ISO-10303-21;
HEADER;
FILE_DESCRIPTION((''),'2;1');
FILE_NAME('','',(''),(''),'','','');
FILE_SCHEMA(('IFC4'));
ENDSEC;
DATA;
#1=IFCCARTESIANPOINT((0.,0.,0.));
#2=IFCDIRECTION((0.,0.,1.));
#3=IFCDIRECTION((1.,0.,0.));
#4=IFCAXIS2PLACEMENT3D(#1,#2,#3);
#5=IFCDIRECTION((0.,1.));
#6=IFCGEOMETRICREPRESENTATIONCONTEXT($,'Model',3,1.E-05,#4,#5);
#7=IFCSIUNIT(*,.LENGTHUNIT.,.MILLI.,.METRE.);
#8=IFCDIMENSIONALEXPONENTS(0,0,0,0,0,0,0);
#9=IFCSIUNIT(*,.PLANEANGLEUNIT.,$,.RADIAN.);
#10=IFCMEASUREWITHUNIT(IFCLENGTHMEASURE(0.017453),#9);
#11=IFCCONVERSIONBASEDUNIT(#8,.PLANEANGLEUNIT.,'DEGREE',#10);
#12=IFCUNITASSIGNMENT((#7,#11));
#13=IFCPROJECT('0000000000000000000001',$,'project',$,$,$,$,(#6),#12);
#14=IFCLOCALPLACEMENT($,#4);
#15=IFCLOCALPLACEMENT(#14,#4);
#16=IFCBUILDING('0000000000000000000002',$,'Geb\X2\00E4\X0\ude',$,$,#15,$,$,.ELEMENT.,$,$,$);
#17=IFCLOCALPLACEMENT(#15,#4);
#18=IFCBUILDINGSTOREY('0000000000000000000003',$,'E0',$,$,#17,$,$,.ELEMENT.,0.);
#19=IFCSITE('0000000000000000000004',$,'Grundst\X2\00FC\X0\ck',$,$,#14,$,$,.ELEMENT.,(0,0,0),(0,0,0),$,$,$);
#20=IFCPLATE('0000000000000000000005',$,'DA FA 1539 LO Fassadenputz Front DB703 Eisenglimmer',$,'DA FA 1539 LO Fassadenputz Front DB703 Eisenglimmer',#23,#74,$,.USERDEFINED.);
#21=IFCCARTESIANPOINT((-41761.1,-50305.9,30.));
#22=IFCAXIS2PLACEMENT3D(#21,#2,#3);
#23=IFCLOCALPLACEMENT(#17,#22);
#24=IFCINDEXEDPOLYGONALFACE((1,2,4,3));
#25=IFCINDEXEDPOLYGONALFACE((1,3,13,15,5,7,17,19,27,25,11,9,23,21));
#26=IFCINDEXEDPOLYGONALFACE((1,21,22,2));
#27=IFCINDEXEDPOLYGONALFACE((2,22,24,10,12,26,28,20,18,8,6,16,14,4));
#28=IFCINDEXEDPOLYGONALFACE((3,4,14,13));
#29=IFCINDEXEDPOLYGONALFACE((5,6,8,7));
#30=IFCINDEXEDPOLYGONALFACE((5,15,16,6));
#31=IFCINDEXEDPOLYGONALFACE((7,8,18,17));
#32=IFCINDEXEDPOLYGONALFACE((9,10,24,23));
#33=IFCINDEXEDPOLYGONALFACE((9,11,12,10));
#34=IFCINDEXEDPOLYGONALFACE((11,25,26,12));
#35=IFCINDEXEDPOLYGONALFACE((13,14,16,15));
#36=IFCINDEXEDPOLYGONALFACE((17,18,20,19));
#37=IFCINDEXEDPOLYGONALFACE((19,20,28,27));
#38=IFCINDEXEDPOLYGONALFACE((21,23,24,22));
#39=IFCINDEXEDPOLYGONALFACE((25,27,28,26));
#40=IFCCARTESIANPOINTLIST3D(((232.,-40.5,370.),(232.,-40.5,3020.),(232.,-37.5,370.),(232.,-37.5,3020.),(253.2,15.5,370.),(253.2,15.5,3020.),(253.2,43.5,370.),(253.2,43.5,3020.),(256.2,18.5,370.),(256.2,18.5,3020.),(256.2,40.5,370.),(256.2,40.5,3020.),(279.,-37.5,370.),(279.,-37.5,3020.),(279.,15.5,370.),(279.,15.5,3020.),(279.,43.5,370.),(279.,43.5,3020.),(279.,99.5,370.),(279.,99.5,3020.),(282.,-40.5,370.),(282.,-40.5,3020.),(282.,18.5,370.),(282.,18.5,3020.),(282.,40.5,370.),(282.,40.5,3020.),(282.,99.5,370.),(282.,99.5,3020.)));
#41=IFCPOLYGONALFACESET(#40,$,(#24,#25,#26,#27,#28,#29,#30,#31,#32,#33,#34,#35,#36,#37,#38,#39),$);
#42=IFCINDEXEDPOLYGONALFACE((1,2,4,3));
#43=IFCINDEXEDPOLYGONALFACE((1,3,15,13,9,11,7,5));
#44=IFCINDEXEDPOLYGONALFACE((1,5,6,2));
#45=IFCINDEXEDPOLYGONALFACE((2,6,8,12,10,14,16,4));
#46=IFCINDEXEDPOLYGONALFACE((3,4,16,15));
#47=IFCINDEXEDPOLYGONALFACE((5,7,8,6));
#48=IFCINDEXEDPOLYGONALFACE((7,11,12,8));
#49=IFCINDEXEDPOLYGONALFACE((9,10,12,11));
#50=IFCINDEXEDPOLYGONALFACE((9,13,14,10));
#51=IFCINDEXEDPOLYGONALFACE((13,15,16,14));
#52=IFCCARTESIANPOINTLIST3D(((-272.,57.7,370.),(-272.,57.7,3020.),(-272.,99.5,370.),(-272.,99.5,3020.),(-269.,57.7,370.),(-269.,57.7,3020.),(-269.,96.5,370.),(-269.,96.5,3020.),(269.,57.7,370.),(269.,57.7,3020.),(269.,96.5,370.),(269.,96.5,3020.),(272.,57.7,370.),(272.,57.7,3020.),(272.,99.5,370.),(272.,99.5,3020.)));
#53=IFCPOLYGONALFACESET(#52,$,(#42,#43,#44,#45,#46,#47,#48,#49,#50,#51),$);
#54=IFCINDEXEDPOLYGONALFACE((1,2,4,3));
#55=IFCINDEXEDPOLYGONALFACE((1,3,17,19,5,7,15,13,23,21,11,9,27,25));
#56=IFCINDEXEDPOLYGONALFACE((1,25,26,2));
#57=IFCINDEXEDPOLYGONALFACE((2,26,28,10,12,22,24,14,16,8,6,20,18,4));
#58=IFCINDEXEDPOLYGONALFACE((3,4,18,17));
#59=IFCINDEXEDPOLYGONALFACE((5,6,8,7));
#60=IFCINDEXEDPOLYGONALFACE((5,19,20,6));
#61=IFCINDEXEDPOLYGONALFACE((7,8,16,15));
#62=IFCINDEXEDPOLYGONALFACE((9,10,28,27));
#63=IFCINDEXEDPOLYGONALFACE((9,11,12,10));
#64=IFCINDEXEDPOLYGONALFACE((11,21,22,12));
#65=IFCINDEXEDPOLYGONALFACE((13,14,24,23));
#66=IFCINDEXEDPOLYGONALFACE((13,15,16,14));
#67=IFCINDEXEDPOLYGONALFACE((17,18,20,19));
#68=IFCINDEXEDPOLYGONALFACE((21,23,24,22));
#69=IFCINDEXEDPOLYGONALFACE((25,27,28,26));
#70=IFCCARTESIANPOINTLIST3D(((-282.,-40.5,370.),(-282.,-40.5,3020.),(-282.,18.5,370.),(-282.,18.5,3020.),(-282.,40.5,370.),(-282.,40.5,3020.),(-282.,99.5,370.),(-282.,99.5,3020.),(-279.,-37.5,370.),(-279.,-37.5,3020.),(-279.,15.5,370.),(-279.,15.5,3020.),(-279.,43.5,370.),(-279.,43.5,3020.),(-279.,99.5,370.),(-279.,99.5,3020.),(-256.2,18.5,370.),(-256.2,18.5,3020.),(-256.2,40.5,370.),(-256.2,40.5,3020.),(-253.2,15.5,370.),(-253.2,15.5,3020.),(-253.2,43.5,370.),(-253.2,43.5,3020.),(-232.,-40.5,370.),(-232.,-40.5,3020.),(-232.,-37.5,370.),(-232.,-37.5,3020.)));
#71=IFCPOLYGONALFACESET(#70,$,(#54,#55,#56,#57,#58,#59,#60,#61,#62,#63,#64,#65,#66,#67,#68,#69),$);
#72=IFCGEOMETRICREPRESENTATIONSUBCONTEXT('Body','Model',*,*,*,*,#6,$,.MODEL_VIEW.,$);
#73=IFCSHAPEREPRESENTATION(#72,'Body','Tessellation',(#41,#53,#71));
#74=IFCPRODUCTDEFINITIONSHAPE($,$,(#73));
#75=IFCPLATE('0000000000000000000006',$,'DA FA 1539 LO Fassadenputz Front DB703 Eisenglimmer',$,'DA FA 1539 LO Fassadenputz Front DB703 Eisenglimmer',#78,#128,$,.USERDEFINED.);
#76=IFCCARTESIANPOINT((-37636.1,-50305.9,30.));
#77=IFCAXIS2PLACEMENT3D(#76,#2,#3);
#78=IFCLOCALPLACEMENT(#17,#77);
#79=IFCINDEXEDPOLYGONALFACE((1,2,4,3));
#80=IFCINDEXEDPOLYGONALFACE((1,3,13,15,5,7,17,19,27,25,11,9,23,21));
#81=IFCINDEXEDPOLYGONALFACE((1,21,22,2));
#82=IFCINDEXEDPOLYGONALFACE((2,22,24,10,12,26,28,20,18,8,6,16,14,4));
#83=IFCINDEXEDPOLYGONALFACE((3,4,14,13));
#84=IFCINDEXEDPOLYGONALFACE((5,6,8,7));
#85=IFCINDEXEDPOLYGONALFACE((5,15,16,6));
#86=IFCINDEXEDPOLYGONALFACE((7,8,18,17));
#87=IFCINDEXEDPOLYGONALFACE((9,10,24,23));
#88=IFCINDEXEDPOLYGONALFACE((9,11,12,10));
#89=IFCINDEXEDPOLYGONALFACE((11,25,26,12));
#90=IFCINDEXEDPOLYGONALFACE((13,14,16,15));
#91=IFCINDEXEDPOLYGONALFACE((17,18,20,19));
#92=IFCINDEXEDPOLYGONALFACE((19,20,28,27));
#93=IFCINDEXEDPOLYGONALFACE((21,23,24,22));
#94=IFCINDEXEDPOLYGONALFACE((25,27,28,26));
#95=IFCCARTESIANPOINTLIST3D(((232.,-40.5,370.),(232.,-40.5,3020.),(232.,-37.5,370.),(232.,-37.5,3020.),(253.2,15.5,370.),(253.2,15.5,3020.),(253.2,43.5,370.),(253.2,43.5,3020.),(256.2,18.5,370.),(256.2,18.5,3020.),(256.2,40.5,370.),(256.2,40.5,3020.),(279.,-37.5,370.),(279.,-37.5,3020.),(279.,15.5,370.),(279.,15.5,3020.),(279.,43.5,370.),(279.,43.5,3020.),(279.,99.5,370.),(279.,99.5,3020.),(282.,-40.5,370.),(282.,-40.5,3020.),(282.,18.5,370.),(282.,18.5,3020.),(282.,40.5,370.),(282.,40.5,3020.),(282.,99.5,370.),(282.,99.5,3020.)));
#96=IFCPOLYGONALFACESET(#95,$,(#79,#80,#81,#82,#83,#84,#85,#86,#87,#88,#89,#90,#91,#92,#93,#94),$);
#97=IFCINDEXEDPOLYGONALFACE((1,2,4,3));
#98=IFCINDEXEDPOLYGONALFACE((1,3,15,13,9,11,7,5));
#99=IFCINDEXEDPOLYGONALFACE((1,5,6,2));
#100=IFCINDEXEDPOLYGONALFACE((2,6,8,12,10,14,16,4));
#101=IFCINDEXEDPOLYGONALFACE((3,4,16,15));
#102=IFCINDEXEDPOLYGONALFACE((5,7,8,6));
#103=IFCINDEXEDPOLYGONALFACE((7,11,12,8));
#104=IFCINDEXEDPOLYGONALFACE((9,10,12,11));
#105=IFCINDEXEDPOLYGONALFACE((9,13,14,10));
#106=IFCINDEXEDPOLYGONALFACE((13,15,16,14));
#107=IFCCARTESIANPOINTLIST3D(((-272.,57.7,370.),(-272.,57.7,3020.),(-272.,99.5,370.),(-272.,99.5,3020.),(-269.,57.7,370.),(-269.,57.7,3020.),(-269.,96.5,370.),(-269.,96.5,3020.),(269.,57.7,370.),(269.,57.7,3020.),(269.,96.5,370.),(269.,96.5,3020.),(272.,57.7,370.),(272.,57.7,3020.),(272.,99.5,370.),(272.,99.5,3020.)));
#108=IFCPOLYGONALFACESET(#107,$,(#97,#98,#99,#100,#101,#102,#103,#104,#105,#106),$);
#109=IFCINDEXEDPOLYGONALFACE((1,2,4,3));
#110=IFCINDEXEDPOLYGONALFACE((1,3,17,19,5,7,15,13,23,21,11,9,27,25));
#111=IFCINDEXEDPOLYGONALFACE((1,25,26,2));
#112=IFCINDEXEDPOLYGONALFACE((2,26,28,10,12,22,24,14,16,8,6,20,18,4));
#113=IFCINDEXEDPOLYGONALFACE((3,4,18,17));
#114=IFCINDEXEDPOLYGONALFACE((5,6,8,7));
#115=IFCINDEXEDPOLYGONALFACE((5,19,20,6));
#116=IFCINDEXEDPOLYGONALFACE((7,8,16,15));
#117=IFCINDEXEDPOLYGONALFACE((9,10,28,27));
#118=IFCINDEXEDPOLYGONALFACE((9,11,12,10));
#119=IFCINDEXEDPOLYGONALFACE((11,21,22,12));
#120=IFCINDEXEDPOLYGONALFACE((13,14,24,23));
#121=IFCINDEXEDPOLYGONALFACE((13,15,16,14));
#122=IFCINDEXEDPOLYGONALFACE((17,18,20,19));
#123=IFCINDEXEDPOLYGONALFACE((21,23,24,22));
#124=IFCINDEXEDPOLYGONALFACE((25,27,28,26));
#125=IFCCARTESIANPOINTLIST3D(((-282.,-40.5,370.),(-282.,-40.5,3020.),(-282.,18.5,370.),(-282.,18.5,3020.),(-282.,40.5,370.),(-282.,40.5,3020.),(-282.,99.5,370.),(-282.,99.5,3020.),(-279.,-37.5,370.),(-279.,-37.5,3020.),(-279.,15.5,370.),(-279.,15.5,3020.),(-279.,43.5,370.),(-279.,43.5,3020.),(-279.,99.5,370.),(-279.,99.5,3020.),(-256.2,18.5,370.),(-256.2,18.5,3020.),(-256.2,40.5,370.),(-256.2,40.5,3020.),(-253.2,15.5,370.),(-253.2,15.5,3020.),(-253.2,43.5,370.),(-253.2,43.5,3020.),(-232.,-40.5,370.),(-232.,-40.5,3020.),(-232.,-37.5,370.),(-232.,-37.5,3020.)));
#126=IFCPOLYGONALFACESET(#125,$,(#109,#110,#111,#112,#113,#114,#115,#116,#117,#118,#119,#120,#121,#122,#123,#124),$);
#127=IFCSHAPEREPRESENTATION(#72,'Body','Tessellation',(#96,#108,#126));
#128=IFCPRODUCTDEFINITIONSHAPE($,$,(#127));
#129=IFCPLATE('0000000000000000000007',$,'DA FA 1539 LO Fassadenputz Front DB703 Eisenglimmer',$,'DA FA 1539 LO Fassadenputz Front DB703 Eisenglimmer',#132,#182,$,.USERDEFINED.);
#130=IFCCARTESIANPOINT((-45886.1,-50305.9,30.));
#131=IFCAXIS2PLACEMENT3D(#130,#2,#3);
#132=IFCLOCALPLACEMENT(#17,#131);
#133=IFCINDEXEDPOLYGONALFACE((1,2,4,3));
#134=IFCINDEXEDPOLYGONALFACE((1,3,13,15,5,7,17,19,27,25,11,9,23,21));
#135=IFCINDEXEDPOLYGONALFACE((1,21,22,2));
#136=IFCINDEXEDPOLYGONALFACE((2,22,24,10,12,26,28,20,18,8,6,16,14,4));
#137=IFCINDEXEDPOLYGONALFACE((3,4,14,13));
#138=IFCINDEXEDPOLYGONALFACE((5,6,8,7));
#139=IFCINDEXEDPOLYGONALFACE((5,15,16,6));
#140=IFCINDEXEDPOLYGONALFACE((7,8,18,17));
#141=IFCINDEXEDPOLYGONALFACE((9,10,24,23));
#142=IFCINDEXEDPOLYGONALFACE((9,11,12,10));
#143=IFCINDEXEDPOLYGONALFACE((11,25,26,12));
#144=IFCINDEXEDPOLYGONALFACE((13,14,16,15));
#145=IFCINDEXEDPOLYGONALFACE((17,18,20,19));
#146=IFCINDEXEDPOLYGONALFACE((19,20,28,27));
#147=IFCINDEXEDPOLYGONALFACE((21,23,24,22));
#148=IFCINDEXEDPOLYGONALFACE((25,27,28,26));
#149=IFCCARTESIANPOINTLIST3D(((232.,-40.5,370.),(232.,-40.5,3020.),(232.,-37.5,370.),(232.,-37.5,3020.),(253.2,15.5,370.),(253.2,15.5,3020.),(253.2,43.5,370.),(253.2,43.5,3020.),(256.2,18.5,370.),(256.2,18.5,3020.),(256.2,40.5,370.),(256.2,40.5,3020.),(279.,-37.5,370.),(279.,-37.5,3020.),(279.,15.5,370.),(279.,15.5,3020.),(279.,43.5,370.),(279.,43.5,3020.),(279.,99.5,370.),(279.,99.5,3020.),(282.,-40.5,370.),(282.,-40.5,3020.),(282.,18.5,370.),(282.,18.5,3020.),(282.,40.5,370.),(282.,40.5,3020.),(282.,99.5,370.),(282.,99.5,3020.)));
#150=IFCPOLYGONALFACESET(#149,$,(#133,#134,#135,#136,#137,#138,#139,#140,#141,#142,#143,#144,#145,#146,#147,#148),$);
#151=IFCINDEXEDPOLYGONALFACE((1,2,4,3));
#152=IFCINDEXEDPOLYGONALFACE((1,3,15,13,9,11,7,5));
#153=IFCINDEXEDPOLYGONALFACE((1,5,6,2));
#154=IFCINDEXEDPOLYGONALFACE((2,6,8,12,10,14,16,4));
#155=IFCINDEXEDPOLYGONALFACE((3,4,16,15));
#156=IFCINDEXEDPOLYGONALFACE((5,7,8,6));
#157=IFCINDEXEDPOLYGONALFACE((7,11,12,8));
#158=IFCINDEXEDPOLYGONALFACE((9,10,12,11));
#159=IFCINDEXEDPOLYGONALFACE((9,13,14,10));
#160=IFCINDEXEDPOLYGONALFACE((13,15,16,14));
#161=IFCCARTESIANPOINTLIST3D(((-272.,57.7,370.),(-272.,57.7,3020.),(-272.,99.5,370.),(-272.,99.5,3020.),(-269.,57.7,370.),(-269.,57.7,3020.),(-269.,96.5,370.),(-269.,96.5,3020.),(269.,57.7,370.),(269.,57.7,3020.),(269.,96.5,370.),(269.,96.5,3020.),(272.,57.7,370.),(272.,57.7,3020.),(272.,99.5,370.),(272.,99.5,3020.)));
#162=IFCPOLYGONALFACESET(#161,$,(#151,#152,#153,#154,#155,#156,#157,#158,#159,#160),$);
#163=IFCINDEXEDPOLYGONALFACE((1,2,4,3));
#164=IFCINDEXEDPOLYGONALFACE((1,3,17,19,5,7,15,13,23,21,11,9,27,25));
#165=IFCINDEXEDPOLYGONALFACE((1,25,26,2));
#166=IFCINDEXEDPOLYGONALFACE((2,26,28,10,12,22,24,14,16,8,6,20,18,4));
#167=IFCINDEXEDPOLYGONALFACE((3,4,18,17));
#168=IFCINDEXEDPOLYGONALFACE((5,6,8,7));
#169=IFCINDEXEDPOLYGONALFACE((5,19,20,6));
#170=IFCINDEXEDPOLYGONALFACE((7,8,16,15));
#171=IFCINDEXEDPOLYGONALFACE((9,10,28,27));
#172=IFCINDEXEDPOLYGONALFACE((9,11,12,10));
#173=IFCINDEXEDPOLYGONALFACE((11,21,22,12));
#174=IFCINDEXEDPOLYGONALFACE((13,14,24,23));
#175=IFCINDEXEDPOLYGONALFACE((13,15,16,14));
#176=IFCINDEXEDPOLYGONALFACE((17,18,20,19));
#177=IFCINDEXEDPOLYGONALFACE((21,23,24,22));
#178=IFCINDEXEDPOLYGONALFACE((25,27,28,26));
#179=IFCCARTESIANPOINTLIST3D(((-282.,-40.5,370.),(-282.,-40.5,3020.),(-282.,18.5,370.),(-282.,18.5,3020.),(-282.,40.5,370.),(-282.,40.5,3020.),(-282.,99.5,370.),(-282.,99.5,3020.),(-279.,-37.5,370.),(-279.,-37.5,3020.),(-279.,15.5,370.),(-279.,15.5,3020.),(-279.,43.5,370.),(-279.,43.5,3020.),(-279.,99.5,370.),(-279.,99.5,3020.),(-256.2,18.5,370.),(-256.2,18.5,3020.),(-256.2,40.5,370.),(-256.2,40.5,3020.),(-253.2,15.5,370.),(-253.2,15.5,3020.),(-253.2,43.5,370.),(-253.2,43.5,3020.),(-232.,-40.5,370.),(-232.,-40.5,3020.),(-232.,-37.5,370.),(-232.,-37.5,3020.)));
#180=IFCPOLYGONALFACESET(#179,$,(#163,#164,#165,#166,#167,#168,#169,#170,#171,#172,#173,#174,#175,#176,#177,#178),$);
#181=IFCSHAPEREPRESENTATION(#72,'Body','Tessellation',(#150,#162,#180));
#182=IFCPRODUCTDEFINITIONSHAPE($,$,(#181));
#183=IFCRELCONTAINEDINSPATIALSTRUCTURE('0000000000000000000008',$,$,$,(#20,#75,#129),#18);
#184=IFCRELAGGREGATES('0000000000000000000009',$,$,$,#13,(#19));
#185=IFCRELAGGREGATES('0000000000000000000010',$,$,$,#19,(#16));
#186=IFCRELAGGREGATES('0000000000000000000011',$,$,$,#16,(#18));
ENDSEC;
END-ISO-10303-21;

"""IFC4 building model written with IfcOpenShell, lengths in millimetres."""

from ifc_helpers import new_model, entity, si_unit, converted_unit, direction, frame, origin_with_axes, place, context, subcontext, project, spatial, line, indexed_curve, outline, extrude, source, transform, mapped, element, save


model = new_model("IFC4")

# Units and contexts
model_context = context("Model", 3, precision=1e-05, world=origin_with_axes(), true_north=direction((0.0, 1.0)))
body_context = subcontext(model_context, "Body", "Model", "MODEL_VIEW")
ifc_project = project(units=[si_unit("LENGTHUNIT", "METRE", prefix="MILLI"), converted_unit("PLANEANGLEUNIT", "DEGREE", entity("IfcLengthMeasure", 0.017453), si_unit("PLANEANGLEUNIT", "RADIAN"), dimensions=[0, 0, 0, 0, 0, 0, 0])], contexts=[model_context])

# Site, building, storey
site_placement = place(None, origin_with_axes())
site = spatial("IfcSite", under=ifc_project, at=site_placement, Name="Grundstück", CompositionType="ELEMENT", RefLatitude=(0, 0, 0), RefLongitude=(0, 0, 0))
building_placement = place(site_placement, origin_with_axes())
building = spatial("IfcBuilding", under=site, at=building_placement, Name="Gebäude", CompositionType="ELEMENT")
storey_placement = place(building_placement, origin_with_axes())
storey = spatial("IfcBuildingStorey", under=building, at=storey_placement, Name="E0", CompositionType="ELEMENT", Elevation=0.0)

# Plates
shared_shape_1 = source(origin_with_axes(), body_context, "Body", "SweptSolid", [
    extrude(outline(indexed_curve([(282.0, 99.5), (282.0, 40.5), (256.2, 40.5), (256.2, 18.5), (282.0, 18.5), (282.0, -40.5), (232.0, -40.5), (232.0, -37.5), (279.0, -37.5), (279.0, 15.5), (253.2, 15.5), (253.2, 43.5), (279.0, 43.5), (279.0, 99.5)], segments=[line(1, 2), line(2, 3), line(3, 4), line(4, 5), line(5, 6), line(6, 7), line(7, 8), line(8, 9), line(9, 10), line(10, 11), line(11, 12), line(12, 13), line(13, 14), line(14, 1)])), frame((0.0, 0.0, 370.0), z_axis=(0.0, 0.0, 1.0), x_axis=(1.0, 0.0, 0.0)), (0.0, 0.0, 1.0), 2650.0),
    extrude(outline(indexed_curve([(272.0, 99.5), (272.0, 57.7), (269.0, 57.7), (269.0, 96.5), (-269.0, 96.5), (-269.0, 57.7), (-272.0, 57.7), (-272.0, 99.5)], segments=[line(1, 2), line(2, 3), line(3, 4), line(4, 5), line(5, 6), line(6, 7), line(7, 8), line(8, 1)])), frame((0.0, 0.0, 370.0), z_axis=(0.0, 0.0, 1.0), x_axis=(1.0, 0.0, 0.0)), (0.0, 0.0, 1.0), 2650.0),
    extrude(outline(indexed_curve([(-282.0, 99.5), (-282.0, 40.5), (-256.2, 40.5), (-256.2, 18.5), (-282.0, 18.5), (-282.0, -40.5), (-232.0, -40.5), (-232.0, -37.5), (-279.0, -37.5), (-279.0, 15.5), (-253.2, 15.5), (-253.2, 43.5), (-279.0, 43.5), (-279.0, 99.5)], segments=[line(1, 2), line(2, 3), line(3, 4), line(4, 5), line(5, 6), line(6, 7), line(7, 8), line(8, 9), line(9, 10), line(10, 11), line(11, 12), line(12, 13), line(13, 14), line(14, 1)])), frame((0.0, 0.0, 370.0), z_axis=(0.0, 0.0, 1.0), x_axis=(1.0, 0.0, 0.0)), (0.0, 0.0, 1.0), 2650.0),
])
for number, where, z_axis, x_axis, name in (
    (1, (-41761.1, -50305.9, 30.0), (0.0, 0.0, 1.0), (1.0, 0.0, 0.0), "DA FA 1539 LO Fassadenputz Front DB703 Eisenglimmer"),
    (2, (-37636.1, -50305.9, 30.0), (0.0, 0.0, 1.0), (1.0, 0.0, 0.0), "DA FA 1539 LO Fassadenputz Front DB703 Eisenglimmer"),
    (3, (-45886.1, -50305.9, 30.0), (0.0, 0.0, 1.0), (1.0, 0.0, 0.0), "DA FA 1539 LO Fassadenputz Front DB703 Eisenglimmer"),
):
    element("IfcPlate", number, at=place(storey_placement, frame(where, z_axis=z_axis, x_axis=x_axis)), inside=storey, Name=name, ObjectType="DA FA 1539 LO Fassadenputz Front DB703 Eisenglimmer", PredefinedType="USERDEFINED", context=body_context, shape_type="MappedRepresentation", body=[
        mapped(shared_shape_1, transform((0.0, 0.0, 0.0), x_axis=(1.0, 0.0, 0.0), y_axis=(0.0, 1.0, 0.0), z_axis=(0.0, 0.0, 1.0), scale=1.0)),
    ])

save(model, "model.ifc")
